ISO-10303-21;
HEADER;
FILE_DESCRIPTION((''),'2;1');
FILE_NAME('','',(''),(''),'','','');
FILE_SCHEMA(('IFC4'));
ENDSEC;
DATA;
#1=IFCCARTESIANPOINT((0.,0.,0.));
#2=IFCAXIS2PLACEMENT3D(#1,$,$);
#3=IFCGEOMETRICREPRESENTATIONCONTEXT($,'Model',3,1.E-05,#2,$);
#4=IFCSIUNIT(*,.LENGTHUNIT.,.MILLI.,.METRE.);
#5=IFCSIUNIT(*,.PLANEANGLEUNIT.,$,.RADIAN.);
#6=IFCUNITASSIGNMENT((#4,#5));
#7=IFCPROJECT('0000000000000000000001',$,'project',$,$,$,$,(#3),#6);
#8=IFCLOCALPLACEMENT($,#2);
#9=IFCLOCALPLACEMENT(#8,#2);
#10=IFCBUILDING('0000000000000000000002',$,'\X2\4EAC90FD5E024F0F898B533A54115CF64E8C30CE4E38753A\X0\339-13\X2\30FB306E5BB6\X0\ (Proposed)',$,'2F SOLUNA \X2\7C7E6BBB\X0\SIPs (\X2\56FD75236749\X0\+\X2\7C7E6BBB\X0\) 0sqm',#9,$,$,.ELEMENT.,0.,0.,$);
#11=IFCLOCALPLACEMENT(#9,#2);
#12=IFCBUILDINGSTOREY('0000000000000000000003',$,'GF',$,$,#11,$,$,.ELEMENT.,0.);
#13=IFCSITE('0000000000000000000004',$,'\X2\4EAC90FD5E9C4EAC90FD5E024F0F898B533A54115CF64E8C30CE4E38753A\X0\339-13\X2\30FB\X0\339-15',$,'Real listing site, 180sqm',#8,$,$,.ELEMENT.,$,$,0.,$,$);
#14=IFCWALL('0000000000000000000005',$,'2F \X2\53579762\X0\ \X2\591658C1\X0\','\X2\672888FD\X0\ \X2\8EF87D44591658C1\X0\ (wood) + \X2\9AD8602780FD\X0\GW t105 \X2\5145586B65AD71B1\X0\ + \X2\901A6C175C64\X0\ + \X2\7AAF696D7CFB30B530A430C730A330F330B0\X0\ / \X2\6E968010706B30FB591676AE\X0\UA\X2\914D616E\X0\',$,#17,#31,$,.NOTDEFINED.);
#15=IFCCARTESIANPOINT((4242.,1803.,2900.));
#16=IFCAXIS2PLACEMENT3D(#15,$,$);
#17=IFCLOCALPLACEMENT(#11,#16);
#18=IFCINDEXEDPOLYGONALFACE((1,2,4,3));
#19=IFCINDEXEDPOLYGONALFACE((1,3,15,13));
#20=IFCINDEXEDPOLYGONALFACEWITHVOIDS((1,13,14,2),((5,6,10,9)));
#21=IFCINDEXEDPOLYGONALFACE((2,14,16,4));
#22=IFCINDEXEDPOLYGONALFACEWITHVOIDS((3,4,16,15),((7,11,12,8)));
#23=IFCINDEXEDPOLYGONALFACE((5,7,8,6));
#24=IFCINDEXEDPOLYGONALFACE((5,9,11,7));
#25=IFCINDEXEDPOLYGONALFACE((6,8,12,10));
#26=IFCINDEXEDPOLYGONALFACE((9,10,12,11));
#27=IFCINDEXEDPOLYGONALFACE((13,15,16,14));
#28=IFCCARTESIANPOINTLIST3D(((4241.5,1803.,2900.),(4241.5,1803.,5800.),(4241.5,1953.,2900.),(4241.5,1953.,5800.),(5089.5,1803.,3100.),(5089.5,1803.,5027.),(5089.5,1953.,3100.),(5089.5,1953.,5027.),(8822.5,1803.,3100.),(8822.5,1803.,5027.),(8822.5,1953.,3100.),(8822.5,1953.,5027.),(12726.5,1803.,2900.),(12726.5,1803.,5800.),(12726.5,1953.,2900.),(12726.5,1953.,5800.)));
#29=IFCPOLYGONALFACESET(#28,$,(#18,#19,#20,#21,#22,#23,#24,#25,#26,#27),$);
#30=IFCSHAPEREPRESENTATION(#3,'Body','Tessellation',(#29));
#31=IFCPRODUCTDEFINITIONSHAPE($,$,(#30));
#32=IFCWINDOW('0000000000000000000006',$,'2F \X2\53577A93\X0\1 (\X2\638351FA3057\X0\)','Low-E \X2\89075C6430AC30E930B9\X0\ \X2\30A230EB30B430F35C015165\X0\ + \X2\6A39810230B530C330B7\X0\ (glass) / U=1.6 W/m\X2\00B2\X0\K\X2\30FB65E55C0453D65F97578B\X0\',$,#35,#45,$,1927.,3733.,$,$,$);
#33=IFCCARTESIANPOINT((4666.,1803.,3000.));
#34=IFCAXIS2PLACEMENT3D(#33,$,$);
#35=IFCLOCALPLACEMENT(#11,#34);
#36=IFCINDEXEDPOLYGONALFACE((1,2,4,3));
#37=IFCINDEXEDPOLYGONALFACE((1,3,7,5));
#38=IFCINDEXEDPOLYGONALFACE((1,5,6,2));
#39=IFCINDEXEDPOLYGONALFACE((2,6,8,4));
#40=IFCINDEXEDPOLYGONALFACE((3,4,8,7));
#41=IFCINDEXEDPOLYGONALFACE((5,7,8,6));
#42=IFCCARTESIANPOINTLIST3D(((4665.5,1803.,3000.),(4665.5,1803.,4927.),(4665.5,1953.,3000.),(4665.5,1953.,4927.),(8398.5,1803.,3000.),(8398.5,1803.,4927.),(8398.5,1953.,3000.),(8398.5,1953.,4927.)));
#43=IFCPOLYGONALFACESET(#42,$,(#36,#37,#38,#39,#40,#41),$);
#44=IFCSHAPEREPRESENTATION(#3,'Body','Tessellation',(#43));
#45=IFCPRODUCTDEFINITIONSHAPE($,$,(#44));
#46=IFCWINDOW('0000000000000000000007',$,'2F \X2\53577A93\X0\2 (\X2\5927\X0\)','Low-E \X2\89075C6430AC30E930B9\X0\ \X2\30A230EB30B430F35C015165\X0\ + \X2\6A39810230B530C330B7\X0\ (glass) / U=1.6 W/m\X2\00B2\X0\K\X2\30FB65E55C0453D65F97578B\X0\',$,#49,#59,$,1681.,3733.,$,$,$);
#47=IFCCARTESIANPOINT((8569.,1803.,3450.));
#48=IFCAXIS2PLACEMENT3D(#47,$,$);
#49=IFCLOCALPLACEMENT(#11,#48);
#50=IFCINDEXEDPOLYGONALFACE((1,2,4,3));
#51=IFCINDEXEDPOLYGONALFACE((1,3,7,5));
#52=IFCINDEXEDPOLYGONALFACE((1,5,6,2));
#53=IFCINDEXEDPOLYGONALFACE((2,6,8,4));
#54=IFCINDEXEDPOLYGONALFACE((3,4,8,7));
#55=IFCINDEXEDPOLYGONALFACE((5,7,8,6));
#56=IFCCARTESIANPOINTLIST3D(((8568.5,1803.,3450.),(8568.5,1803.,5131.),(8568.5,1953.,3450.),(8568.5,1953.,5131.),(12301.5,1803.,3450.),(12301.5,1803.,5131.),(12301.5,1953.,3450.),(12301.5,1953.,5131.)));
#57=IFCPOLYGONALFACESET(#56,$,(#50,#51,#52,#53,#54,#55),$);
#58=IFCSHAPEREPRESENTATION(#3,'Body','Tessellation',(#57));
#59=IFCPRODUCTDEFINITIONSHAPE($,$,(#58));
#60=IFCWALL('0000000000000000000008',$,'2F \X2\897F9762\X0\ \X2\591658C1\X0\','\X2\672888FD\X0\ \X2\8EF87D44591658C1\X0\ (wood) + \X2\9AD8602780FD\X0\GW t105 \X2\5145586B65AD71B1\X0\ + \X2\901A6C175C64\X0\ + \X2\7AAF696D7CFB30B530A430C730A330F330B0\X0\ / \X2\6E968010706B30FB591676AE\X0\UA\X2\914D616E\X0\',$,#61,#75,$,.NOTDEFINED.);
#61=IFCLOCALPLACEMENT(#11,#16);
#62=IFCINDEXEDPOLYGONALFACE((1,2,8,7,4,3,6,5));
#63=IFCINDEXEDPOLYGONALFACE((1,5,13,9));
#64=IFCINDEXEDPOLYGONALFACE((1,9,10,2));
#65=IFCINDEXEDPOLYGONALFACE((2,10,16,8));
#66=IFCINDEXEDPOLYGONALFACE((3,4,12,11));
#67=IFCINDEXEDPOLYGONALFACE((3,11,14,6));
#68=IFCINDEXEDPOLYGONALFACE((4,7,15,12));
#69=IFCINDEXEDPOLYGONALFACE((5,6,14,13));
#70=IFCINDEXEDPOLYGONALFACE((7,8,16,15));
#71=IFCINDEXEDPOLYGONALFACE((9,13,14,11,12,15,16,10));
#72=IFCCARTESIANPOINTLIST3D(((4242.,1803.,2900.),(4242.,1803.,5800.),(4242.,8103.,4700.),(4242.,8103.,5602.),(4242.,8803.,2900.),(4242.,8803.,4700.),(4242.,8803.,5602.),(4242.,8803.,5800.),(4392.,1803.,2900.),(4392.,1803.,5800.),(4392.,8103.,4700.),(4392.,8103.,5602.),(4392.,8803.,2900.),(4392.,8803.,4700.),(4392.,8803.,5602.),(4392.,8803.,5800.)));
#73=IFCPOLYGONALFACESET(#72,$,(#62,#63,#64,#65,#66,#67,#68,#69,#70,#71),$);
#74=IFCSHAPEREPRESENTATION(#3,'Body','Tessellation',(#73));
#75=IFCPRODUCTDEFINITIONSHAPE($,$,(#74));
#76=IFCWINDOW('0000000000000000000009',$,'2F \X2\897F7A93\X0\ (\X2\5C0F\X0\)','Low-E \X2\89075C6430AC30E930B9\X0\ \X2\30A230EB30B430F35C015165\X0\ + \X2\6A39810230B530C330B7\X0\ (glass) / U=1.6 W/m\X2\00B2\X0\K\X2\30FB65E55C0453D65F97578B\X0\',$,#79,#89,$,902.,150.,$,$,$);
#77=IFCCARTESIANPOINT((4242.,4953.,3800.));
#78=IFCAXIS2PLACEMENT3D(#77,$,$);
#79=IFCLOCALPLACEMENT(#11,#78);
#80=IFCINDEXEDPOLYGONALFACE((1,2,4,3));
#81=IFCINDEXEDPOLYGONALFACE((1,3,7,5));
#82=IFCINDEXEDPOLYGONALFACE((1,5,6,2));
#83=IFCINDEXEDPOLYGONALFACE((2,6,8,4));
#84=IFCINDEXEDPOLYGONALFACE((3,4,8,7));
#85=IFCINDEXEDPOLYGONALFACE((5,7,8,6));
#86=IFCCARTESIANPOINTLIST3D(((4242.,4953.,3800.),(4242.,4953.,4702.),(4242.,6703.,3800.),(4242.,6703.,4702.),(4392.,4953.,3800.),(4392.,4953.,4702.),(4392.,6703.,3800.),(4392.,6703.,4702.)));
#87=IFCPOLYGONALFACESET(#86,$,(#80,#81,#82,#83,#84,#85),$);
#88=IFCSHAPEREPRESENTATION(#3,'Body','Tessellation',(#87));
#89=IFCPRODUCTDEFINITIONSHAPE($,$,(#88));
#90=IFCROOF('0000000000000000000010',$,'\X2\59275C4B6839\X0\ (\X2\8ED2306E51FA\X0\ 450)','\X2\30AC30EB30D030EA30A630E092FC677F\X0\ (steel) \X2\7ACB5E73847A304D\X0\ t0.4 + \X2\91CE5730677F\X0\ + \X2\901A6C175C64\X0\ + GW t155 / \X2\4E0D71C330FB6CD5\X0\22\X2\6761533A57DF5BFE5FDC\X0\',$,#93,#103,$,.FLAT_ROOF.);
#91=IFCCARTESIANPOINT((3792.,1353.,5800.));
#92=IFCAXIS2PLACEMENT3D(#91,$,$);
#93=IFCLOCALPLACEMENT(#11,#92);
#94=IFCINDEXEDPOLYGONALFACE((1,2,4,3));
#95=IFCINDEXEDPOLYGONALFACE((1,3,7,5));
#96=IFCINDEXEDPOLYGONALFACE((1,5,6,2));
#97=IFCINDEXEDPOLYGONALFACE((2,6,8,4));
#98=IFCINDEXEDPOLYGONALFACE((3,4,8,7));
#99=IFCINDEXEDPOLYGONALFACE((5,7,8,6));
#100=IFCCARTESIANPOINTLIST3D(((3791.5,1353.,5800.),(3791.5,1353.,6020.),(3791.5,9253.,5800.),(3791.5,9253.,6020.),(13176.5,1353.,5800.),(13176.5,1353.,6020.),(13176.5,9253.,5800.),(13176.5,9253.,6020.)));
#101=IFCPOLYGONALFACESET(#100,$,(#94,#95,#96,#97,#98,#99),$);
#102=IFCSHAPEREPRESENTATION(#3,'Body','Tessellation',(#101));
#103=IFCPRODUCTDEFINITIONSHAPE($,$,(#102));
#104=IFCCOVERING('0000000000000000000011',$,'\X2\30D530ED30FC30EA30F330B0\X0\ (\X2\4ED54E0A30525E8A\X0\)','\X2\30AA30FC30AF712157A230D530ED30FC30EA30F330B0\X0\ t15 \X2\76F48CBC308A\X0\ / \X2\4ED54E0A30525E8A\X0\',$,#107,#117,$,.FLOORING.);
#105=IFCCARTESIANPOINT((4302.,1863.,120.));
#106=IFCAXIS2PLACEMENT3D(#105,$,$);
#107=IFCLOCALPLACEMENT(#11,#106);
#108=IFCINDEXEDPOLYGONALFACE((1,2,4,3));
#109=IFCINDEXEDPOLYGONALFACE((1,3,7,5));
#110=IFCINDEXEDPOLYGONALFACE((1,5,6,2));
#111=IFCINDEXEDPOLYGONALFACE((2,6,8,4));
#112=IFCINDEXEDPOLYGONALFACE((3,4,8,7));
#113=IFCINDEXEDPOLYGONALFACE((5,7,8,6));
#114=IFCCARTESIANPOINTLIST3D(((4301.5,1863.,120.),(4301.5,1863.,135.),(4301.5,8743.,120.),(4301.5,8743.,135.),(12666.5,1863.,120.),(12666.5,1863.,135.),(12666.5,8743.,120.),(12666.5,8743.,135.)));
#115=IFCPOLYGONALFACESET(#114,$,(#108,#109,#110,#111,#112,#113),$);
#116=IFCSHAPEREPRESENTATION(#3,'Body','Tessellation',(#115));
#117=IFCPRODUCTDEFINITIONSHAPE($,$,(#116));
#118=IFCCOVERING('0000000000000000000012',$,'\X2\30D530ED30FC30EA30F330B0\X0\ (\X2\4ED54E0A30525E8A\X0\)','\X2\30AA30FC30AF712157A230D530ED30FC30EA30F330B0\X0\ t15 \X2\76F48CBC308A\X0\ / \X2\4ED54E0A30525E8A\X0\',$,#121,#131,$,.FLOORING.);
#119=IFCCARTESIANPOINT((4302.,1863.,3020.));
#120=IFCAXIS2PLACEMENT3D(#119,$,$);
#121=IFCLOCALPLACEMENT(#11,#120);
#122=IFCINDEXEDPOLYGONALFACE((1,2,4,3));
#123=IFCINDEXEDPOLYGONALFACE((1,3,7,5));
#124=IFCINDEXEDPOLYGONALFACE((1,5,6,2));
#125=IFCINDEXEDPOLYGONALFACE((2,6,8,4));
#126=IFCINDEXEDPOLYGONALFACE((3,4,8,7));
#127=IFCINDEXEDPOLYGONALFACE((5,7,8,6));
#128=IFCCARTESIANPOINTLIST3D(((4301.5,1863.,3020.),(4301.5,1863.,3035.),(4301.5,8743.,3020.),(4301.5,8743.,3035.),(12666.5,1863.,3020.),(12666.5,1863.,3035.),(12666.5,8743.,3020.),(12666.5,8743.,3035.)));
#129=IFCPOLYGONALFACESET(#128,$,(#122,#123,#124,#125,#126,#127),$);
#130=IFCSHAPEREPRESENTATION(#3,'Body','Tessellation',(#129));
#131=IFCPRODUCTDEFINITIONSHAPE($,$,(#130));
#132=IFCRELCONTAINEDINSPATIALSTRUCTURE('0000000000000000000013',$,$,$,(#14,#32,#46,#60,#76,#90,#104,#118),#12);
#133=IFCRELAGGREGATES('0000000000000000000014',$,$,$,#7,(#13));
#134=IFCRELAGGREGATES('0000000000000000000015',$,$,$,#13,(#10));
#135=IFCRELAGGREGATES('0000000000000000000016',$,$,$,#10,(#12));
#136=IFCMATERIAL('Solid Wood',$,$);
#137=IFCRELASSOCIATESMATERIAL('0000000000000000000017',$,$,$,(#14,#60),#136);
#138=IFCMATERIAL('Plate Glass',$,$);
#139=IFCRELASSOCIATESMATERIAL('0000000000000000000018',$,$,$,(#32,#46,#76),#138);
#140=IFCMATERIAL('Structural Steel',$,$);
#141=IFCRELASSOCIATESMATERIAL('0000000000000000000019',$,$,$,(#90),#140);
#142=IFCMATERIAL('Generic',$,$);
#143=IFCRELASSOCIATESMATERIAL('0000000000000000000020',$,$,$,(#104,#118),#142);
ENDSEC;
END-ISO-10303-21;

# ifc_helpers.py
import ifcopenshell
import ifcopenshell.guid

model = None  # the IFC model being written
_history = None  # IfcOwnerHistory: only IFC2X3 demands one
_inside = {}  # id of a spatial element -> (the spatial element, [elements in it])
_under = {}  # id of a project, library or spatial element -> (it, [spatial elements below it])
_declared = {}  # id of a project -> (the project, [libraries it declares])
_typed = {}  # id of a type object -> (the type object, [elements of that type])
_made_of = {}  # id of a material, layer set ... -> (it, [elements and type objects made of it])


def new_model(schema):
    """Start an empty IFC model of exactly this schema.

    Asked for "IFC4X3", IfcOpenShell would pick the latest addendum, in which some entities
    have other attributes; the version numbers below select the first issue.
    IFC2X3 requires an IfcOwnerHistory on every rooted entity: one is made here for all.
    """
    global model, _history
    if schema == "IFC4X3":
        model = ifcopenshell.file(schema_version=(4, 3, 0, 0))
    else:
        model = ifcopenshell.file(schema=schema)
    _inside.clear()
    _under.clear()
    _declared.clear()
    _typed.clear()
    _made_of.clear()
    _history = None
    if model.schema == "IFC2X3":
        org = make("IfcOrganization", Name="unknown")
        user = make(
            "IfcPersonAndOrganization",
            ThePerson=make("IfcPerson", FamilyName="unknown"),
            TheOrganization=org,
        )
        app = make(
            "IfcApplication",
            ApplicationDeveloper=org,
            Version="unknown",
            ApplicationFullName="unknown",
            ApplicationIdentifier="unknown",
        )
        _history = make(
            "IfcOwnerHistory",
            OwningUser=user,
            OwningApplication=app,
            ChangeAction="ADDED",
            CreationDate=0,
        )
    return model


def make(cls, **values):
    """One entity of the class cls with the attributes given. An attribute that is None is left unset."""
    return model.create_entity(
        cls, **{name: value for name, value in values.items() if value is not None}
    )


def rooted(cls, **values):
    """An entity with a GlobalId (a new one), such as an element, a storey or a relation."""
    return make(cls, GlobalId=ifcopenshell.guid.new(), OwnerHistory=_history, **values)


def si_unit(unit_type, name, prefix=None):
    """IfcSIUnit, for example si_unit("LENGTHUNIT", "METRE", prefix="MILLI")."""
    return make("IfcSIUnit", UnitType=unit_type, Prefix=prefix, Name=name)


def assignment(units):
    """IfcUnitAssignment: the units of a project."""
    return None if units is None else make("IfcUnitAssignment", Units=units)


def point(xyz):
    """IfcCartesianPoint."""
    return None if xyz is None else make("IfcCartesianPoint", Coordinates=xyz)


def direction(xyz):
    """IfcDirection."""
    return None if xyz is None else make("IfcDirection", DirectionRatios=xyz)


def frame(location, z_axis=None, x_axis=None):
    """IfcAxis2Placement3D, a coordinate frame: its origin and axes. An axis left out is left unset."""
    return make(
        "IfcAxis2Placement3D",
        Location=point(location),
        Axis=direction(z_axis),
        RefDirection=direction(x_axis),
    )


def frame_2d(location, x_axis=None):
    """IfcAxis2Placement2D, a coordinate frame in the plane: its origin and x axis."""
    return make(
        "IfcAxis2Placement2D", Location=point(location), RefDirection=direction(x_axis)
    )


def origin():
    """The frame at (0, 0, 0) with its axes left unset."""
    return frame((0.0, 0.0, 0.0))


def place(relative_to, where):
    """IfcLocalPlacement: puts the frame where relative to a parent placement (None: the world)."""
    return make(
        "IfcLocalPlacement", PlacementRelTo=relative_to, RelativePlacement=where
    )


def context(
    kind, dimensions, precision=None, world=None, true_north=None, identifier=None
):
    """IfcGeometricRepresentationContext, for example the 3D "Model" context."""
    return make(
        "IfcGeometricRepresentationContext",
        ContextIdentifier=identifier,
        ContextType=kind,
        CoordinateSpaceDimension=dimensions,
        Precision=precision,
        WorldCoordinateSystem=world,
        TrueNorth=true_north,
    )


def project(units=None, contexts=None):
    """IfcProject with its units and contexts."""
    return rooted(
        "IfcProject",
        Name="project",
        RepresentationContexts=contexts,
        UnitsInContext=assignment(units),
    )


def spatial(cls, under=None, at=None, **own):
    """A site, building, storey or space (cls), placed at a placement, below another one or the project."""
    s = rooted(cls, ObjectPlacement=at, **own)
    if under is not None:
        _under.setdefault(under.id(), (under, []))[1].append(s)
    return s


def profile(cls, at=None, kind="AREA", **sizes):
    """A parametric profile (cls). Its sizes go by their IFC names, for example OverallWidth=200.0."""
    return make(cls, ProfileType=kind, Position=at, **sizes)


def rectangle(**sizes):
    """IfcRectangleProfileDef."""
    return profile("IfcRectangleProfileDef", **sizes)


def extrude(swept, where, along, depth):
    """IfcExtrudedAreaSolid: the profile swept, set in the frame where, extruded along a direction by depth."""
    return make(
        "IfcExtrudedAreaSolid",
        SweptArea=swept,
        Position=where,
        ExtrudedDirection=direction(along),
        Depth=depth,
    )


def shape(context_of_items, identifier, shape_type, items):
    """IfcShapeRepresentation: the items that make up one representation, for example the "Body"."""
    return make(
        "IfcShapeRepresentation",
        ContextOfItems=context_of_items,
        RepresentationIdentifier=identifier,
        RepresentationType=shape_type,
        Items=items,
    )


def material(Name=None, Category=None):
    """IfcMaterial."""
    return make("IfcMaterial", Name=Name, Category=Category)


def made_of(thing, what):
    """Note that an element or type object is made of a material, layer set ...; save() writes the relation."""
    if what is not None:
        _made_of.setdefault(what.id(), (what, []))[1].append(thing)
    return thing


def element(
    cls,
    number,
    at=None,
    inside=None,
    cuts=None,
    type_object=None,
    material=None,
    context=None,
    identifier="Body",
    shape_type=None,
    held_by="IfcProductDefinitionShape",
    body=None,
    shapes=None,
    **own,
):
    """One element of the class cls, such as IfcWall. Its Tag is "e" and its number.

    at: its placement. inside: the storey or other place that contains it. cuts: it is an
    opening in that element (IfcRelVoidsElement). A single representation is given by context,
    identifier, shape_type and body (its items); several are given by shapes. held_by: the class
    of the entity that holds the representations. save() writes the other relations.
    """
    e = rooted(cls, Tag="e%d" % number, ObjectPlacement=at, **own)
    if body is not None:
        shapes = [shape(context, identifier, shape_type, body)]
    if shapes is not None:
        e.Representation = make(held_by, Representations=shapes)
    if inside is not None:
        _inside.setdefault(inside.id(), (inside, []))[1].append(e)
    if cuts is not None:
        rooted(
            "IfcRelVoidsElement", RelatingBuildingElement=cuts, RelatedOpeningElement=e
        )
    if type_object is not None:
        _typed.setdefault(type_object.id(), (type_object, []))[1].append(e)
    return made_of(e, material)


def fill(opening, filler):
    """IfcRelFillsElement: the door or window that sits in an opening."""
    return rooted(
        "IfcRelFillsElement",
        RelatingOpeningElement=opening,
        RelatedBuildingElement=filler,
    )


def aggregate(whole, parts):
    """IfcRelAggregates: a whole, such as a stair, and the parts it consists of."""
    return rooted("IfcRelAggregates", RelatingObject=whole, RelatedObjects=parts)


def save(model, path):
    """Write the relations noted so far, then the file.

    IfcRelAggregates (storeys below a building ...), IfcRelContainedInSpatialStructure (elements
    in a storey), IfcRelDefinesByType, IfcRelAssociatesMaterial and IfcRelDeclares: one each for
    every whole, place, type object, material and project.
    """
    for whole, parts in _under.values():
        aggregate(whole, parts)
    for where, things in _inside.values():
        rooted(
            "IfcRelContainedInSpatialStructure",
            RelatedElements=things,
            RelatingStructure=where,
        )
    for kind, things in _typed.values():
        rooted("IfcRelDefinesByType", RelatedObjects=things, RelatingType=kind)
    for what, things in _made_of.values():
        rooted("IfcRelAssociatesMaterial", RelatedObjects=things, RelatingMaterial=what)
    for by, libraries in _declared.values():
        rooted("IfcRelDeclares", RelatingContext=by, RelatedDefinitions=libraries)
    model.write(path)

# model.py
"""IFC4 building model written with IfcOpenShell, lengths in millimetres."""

from ifc_helpers import new_model, si_unit, frame, frame_2d, origin, place, context, project, spatial, rectangle, extrude, material, element, fill, save


model = new_model("IFC4")

# Units and contexts
model_context = context("Model", 3, precision=1e-05, world=origin())
ifc_project = project(units=[si_unit("LENGTHUNIT", "METRE", prefix="MILLI"), si_unit("PLANEANGLEUNIT", "RADIAN")], contexts=[model_context])

# Site, building, storey
site_placement = place(None, origin())
site = spatial("IfcSite", under=ifc_project, at=site_placement, Name="京都府京都市伏見区向島二ノ丸町339-13・339-15", ObjectType="Real listing site, 180sqm", CompositionType="ELEMENT", RefElevation=0.0)
building_placement = place(site_placement, origin())
building = spatial("IfcBuilding", under=site, at=building_placement, Name="京都市伏見区向島二ノ丸町339-13・の家 (Proposed)", ObjectType="2F SOLUNA 籾殻SIPs (国産杉+籾殻) 0sqm", CompositionType="ELEMENT", ElevationOfRefHeight=0.0, ElevationOfTerrain=0.0)
storey_placement = place(building_placement, origin())
storey = spatial("IfcBuildingStorey", under=building, at=storey_placement, Name="GF", CompositionType="ELEMENT", Elevation=0.0)

# Shared definitions
ifc_material_1 = material(Name="Solid Wood")

# Shared definitions
ifc_material_2 = material(Name="Plate Glass")

# Wall, openings, windows
wall_1_placement = place(storey_placement, frame((4242.0, 1803.0, 2900.0)))
wall_1 = element("IfcWall", 1, at=wall_1_placement, inside=storey, material=ifc_material_1, Name="2F 南面 外壁", Description="木製 軸組外壁 (wood) + 高性能GW t105 充填断熱 + 通気層 + 窯業系サイディング / 準耐火・外皮UA配慮", PredefinedType="NOTDEFINED", context=model_context, shape_type="SweptSolid", body=[
    extrude(rectangle(XDim=8485.0, YDim=150.0, at=frame_2d((4242.0, 75.0))), frame((4242.0, 1803.0, 2900.0)), (0.0, 0.0, 1.0), 2900.0),
])
opening_1_placement = place(storey_placement, frame((4666.0, 1803.0, 3000.0)))
opening_1 = element("IfcOpeningElement", 2, at=opening_1_placement, cuts=wall_1, PredefinedType="NOTDEFINED", context=model_context, shape_type="SweptSolid", body=[
    extrude(rectangle(XDim=3733.0, YDim=150.0, at=frame_2d((1866.0, 75.0))), frame((4666.0, 1803.0, 3000.0)), (0.0, 0.0, 1.0), 1927.0),
])
opening_2_placement = place(storey_placement, frame((8569.0, 1803.0, 3450.0)))
opening_2 = element("IfcOpeningElement", 3, at=opening_2_placement, cuts=wall_1, PredefinedType="NOTDEFINED", context=model_context, shape_type="SweptSolid", body=[
    extrude(rectangle(XDim=3733.0, YDim=150.0, at=frame_2d((1866.0, 75.0))), frame((8569.0, 1803.0, 3450.0)), (0.0, 0.0, 1.0), 1681.0),
])
window_1_placement = place(storey_placement, frame((4666.0, 1803.0, 3000.0)))
window_1 = element("IfcWindow", 4, at=window_1_placement, inside=storey, material=ifc_material_2, Name="2F 南窓1 (掃出し)", Description="Low-E 複層ガラス アルゴン封入 + 樹脂サッシ (glass) / U=1.6 W/m²K・日射取得型", OverallHeight=1927.0, OverallWidth=3733.0, context=model_context, shape_type="SweptSolid", body=[
    extrude(rectangle(XDim=3733.0, YDim=150.0, at=frame_2d((1866.0, 75.0))), frame((4666.0, 1803.0, 3000.0)), (0.0, 0.0, 1.0), 1927.0),
])
fill(opening_1, window_1)
window_2_placement = place(storey_placement, frame((8569.0, 1803.0, 3450.0)))
window_2 = element("IfcWindow", 5, at=window_2_placement, inside=storey, material=ifc_material_2, Name="2F 南窓2 (大)", Description="Low-E 複層ガラス アルゴン封入 + 樹脂サッシ (glass) / U=1.6 W/m²K・日射取得型", OverallHeight=1681.0, OverallWidth=3733.0, context=model_context, shape_type="SweptSolid", body=[
    extrude(rectangle(XDim=3733.0, YDim=150.0, at=frame_2d((1866.0, 75.0))), frame((8569.0, 1803.0, 3450.0)), (0.0, 0.0, 1.0), 1681.0),
])
fill(opening_2, window_2)

# Wall, opening, window
wall_2_placement = place(storey_placement, frame((4242.0, 1803.0, 2900.0)))
wall_2 = element("IfcWall", 6, at=wall_2_placement, inside=storey, material=ifc_material_1, Name="2F 西面 外壁", Description="木製 軸組外壁 (wood) + 高性能GW t105 充填断熱 + 通気層 + 窯業系サイディング / 準耐火・外皮UA配慮", PredefinedType="NOTDEFINED", context=model_context, shape_type="SweptSolid", body=[
    extrude(rectangle(XDim=150.0, YDim=7000.0, at=frame_2d((75.0, 3500.0))), frame((4242.0, 1803.0, 2900.0)), (0.0, 0.0, 1.0), 2900.0),
])
opening_3_placement = place(storey_placement, frame((4242.0, 4953.0, 3800.0)))
opening_3 = element("IfcOpeningElement", 7, at=opening_3_placement, cuts=wall_2, PredefinedType="NOTDEFINED", context=model_context, shape_type="SweptSolid", body=[
    extrude(rectangle(XDim=150.0, YDim=1750.0, at=frame_2d((75.0, 875.0))), frame((4242.0, 4953.0, 3800.0)), (0.0, 0.0, 1.0), 902.0),
])
window_3_placement = place(storey_placement, frame((4242.0, 4953.0, 3800.0)))
window_3 = element("IfcWindow", 8, at=window_3_placement, inside=storey, material=ifc_material_2, Name="2F 西窓 (小)", Description="Low-E 複層ガラス アルゴン封入 + 樹脂サッシ (glass) / U=1.6 W/m²K・日射取得型", OverallHeight=902.0, OverallWidth=150.0, context=model_context, shape_type="SweptSolid", body=[
    extrude(rectangle(XDim=150.0, YDim=1750.0, at=frame_2d((75.0, 875.0))), frame((4242.0, 4953.0, 3800.0)), (0.0, 0.0, 1.0), 902.0),
])
fill(opening_3, window_3)

# Roof
ifc_material_3 = material(Name="Structural Steel")
roof_placement = place(storey_placement, frame((3792.0, 1353.0, 5800.0)))
element("IfcRoof", 9, at=roof_placement, inside=storey, material=ifc_material_3, Name="大屋根 (軒の出 450)", Description="ガルバリウム鋼板 (steel) 立平葺き t0.4 + 野地板 + 通気層 + GW t155 / 不燃・法22条区域対応", PredefinedType="FLAT_ROOF", context=model_context, shape_type="SweptSolid", body=[
    extrude(rectangle(XDim=9385.0, YDim=7900.0, at=frame_2d((4692.0, 3950.0))), frame((3792.0, 1353.0, 5800.0)), (0.0, 0.0, 1.0), 220.0),
])

# Coverings
ifc_material_4 = material(Name="Generic")
covering_1_placement = place(storey_placement, frame((4302.0, 1863.0, 120.0)))
element("IfcCovering", 10, at=covering_1_placement, inside=storey, material=ifc_material_4, Name="フローリング (仕上げ床)", Description="オーク無垢フローリング t15 直貼り / 仕上げ床", PredefinedType="FLOORING", context=model_context, shape_type="SweptSolid", body=[
    extrude(rectangle(XDim=8365.0, YDim=6880.0, at=frame_2d((4182.0, 3440.0))), frame((4302.0, 1863.0, 120.0)), (0.0, 0.0, 1.0), 15.0),
])
covering_2_placement = place(storey_placement, frame((4302.0, 1863.0, 3020.0)))
element("IfcCovering", 11, at=covering_2_placement, inside=storey, material=ifc_material_4, Name="フローリング (仕上げ床)", Description="オーク無垢フローリング t15 直貼り / 仕上げ床", PredefinedType="FLOORING", context=model_context, shape_type="SweptSolid", body=[
    extrude(rectangle(XDim=8365.0, YDim=6880.0, at=frame_2d((4182.0, 3440.0))), frame((4302.0, 1863.0, 3020.0)), (0.0, 0.0, 1.0), 15.0),
])

save(model, "model.ifc")
